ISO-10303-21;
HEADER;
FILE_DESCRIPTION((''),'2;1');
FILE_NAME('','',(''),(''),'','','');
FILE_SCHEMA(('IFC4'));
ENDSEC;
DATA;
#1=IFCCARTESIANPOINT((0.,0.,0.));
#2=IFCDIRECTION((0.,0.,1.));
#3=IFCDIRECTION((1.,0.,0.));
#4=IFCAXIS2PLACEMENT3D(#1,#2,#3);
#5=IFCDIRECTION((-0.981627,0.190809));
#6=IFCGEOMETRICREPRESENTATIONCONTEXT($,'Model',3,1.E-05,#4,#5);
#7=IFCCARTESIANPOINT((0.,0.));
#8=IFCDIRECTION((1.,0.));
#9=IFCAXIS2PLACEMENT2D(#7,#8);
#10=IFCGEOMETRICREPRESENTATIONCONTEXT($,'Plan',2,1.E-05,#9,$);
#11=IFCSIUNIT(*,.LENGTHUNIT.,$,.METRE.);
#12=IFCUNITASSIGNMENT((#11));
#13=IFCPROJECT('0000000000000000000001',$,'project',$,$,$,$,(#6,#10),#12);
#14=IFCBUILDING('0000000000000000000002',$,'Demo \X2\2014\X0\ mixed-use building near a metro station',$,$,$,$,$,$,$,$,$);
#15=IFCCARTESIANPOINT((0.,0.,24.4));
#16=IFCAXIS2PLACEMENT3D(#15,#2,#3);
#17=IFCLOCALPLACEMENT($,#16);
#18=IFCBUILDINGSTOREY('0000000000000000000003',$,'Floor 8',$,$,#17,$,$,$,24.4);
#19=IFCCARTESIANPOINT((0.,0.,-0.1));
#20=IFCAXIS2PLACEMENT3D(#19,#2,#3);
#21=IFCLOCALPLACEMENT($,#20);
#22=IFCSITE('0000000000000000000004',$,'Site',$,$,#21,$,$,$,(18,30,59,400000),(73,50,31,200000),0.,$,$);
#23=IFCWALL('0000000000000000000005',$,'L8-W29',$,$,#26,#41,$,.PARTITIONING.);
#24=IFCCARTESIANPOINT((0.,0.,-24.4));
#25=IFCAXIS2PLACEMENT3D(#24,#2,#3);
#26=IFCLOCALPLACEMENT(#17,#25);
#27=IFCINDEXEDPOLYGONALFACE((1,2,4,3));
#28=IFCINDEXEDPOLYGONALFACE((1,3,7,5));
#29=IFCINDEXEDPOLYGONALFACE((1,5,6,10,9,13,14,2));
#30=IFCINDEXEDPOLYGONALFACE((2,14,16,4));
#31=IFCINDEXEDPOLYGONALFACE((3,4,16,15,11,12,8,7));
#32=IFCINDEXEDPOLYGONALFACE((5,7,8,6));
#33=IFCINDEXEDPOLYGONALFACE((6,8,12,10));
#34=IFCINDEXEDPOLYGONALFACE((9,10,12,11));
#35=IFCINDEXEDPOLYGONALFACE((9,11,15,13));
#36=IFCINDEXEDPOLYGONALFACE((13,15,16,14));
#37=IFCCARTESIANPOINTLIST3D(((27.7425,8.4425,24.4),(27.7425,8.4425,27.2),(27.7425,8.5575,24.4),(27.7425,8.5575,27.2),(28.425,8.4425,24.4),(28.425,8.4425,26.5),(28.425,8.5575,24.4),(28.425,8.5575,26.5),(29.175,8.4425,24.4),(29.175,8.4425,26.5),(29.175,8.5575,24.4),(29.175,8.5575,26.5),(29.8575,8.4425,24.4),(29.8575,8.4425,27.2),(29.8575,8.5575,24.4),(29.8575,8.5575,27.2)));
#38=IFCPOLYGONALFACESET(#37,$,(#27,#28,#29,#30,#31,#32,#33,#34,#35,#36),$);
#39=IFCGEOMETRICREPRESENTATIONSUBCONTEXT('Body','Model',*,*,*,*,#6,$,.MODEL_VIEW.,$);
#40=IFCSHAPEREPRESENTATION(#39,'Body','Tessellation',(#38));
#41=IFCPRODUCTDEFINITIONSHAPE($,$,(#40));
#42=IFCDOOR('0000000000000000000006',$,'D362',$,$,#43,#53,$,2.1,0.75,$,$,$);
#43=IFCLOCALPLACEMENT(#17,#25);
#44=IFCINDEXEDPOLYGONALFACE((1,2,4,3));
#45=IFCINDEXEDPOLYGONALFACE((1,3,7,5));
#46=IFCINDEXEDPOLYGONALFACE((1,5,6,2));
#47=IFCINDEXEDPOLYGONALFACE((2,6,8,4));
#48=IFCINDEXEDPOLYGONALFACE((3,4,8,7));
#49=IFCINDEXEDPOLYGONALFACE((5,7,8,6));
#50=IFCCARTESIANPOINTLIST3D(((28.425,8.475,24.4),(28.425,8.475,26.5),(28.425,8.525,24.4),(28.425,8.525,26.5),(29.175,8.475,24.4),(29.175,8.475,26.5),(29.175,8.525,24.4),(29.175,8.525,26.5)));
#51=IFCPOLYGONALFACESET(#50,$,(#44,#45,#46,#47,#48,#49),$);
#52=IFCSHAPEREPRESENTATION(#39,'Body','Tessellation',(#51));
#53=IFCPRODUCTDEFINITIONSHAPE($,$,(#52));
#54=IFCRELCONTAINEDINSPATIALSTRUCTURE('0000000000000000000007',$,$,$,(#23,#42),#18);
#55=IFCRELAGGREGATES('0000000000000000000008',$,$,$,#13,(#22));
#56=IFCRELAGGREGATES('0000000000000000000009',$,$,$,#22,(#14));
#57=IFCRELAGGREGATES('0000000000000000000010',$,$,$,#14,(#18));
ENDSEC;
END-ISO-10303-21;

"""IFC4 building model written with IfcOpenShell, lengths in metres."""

from ifc_helpers import new_model, si_unit, direction, frame, origin_with_axes, origin_2d_with_axis, place, context, subcontext, project, spatial, line, indexed_curve, outline, extrude, element, fill, save


model = new_model("IFC4")

# Units and contexts
model_context = context("Model", 3, precision=1e-05, world=origin_with_axes(), true_north=direction((-0.981627, 0.190809)))
plan_context = context("Plan", 2, precision=1e-05, world=origin_2d_with_axis())
body_context = subcontext(model_context, "Body", "Model", "MODEL_VIEW")
ifc_project = project(units=[si_unit("LENGTHUNIT", "METRE")], contexts=[model_context, plan_context])

# Site, building, storey
site_placement = place(None, frame((0.0, 0.0, -0.1), z_axis=(0.0, 0.0, 1.0), x_axis=(1.0, 0.0, 0.0)))
site = spatial("IfcSite", under=ifc_project, at=site_placement, Name="Site", RefLatitude=(18, 30, 59, 400000), RefLongitude=(73, 50, 31, 200000), RefElevation=0.0)
building = spatial("IfcBuilding", under=site, Name="Demo — mixed-use building near a metro station")
storey_placement = place(None, frame((0.0, 0.0, 24.4), z_axis=(0.0, 0.0, 1.0), x_axis=(1.0, 0.0, 0.0)))
storey = spatial("IfcBuildingStorey", under=building, at=storey_placement, Name="Floor 8", Elevation=24.4)

# Wall, opening, door
wall_1_placement = place(storey_placement, frame((0.0, 0.0, -24.4), z_axis=(0.0, 0.0, 1.0), x_axis=(1.0, 0.0, 0.0)))
wall_1 = element("IfcWall", 1, at=wall_1_placement, inside=storey, Name="L8-W29", PredefinedType="PARTITIONING", context=body_context, shape_type="SweptSolid", body=[
    extrude(outline(indexed_curve([(29.8575, 8.4425), (27.7425, 8.4425), (27.7425, 8.5575), (29.8575, 8.5575)], segments=[line(1, 2, 3, 4, 1)])), frame((0.0, 0.0, 24.4), z_axis=(0.0, 0.0, 1.0), x_axis=(1.0, 0.0, 0.0)), (0.0, 0.0, 1.0), 2.8),
])
opening_1_placement = place(wall_1_placement, origin_with_axes())
opening_1 = element("IfcOpeningElement", 2, at=opening_1_placement, cuts=wall_1, context=body_context, shape_type="SweptSolid", body=[
    extrude(outline(indexed_curve([(29.175, 8.3925), (28.425, 8.3925), (28.425, 8.6075), (29.175, 8.6075)], segments=[line(1, 2, 3, 4, 1)])), frame((0.0, 0.0, 24.4), z_axis=(0.0, 0.0, 1.0), x_axis=(1.0, 0.0, 0.0)), (0.0, 0.0, 1.0), 2.1),
])
door_1_placement = place(storey_placement, frame((0.0, 0.0, -24.4), z_axis=(0.0, 0.0, 1.0), x_axis=(1.0, 0.0, 0.0)))
door_1 = element("IfcDoor", 3, at=door_1_placement, inside=storey, Name="D362", OverallHeight=2.1, OverallWidth=0.75, context=body_context, shape_type="SweptSolid", body=[
    extrude(outline(indexed_curve([(29.175, 8.475), (28.425, 8.475), (28.425, 8.525), (29.175, 8.525)], segments=[line(1, 2, 3, 4, 1)])), frame((0.0, 0.0, 24.4), z_axis=(0.0, 0.0, 1.0), x_axis=(1.0, 0.0, 0.0)), (0.0, 0.0, 1.0), 2.1),
])
fill(opening_1, door_1)

save(model, "model.ifc")
